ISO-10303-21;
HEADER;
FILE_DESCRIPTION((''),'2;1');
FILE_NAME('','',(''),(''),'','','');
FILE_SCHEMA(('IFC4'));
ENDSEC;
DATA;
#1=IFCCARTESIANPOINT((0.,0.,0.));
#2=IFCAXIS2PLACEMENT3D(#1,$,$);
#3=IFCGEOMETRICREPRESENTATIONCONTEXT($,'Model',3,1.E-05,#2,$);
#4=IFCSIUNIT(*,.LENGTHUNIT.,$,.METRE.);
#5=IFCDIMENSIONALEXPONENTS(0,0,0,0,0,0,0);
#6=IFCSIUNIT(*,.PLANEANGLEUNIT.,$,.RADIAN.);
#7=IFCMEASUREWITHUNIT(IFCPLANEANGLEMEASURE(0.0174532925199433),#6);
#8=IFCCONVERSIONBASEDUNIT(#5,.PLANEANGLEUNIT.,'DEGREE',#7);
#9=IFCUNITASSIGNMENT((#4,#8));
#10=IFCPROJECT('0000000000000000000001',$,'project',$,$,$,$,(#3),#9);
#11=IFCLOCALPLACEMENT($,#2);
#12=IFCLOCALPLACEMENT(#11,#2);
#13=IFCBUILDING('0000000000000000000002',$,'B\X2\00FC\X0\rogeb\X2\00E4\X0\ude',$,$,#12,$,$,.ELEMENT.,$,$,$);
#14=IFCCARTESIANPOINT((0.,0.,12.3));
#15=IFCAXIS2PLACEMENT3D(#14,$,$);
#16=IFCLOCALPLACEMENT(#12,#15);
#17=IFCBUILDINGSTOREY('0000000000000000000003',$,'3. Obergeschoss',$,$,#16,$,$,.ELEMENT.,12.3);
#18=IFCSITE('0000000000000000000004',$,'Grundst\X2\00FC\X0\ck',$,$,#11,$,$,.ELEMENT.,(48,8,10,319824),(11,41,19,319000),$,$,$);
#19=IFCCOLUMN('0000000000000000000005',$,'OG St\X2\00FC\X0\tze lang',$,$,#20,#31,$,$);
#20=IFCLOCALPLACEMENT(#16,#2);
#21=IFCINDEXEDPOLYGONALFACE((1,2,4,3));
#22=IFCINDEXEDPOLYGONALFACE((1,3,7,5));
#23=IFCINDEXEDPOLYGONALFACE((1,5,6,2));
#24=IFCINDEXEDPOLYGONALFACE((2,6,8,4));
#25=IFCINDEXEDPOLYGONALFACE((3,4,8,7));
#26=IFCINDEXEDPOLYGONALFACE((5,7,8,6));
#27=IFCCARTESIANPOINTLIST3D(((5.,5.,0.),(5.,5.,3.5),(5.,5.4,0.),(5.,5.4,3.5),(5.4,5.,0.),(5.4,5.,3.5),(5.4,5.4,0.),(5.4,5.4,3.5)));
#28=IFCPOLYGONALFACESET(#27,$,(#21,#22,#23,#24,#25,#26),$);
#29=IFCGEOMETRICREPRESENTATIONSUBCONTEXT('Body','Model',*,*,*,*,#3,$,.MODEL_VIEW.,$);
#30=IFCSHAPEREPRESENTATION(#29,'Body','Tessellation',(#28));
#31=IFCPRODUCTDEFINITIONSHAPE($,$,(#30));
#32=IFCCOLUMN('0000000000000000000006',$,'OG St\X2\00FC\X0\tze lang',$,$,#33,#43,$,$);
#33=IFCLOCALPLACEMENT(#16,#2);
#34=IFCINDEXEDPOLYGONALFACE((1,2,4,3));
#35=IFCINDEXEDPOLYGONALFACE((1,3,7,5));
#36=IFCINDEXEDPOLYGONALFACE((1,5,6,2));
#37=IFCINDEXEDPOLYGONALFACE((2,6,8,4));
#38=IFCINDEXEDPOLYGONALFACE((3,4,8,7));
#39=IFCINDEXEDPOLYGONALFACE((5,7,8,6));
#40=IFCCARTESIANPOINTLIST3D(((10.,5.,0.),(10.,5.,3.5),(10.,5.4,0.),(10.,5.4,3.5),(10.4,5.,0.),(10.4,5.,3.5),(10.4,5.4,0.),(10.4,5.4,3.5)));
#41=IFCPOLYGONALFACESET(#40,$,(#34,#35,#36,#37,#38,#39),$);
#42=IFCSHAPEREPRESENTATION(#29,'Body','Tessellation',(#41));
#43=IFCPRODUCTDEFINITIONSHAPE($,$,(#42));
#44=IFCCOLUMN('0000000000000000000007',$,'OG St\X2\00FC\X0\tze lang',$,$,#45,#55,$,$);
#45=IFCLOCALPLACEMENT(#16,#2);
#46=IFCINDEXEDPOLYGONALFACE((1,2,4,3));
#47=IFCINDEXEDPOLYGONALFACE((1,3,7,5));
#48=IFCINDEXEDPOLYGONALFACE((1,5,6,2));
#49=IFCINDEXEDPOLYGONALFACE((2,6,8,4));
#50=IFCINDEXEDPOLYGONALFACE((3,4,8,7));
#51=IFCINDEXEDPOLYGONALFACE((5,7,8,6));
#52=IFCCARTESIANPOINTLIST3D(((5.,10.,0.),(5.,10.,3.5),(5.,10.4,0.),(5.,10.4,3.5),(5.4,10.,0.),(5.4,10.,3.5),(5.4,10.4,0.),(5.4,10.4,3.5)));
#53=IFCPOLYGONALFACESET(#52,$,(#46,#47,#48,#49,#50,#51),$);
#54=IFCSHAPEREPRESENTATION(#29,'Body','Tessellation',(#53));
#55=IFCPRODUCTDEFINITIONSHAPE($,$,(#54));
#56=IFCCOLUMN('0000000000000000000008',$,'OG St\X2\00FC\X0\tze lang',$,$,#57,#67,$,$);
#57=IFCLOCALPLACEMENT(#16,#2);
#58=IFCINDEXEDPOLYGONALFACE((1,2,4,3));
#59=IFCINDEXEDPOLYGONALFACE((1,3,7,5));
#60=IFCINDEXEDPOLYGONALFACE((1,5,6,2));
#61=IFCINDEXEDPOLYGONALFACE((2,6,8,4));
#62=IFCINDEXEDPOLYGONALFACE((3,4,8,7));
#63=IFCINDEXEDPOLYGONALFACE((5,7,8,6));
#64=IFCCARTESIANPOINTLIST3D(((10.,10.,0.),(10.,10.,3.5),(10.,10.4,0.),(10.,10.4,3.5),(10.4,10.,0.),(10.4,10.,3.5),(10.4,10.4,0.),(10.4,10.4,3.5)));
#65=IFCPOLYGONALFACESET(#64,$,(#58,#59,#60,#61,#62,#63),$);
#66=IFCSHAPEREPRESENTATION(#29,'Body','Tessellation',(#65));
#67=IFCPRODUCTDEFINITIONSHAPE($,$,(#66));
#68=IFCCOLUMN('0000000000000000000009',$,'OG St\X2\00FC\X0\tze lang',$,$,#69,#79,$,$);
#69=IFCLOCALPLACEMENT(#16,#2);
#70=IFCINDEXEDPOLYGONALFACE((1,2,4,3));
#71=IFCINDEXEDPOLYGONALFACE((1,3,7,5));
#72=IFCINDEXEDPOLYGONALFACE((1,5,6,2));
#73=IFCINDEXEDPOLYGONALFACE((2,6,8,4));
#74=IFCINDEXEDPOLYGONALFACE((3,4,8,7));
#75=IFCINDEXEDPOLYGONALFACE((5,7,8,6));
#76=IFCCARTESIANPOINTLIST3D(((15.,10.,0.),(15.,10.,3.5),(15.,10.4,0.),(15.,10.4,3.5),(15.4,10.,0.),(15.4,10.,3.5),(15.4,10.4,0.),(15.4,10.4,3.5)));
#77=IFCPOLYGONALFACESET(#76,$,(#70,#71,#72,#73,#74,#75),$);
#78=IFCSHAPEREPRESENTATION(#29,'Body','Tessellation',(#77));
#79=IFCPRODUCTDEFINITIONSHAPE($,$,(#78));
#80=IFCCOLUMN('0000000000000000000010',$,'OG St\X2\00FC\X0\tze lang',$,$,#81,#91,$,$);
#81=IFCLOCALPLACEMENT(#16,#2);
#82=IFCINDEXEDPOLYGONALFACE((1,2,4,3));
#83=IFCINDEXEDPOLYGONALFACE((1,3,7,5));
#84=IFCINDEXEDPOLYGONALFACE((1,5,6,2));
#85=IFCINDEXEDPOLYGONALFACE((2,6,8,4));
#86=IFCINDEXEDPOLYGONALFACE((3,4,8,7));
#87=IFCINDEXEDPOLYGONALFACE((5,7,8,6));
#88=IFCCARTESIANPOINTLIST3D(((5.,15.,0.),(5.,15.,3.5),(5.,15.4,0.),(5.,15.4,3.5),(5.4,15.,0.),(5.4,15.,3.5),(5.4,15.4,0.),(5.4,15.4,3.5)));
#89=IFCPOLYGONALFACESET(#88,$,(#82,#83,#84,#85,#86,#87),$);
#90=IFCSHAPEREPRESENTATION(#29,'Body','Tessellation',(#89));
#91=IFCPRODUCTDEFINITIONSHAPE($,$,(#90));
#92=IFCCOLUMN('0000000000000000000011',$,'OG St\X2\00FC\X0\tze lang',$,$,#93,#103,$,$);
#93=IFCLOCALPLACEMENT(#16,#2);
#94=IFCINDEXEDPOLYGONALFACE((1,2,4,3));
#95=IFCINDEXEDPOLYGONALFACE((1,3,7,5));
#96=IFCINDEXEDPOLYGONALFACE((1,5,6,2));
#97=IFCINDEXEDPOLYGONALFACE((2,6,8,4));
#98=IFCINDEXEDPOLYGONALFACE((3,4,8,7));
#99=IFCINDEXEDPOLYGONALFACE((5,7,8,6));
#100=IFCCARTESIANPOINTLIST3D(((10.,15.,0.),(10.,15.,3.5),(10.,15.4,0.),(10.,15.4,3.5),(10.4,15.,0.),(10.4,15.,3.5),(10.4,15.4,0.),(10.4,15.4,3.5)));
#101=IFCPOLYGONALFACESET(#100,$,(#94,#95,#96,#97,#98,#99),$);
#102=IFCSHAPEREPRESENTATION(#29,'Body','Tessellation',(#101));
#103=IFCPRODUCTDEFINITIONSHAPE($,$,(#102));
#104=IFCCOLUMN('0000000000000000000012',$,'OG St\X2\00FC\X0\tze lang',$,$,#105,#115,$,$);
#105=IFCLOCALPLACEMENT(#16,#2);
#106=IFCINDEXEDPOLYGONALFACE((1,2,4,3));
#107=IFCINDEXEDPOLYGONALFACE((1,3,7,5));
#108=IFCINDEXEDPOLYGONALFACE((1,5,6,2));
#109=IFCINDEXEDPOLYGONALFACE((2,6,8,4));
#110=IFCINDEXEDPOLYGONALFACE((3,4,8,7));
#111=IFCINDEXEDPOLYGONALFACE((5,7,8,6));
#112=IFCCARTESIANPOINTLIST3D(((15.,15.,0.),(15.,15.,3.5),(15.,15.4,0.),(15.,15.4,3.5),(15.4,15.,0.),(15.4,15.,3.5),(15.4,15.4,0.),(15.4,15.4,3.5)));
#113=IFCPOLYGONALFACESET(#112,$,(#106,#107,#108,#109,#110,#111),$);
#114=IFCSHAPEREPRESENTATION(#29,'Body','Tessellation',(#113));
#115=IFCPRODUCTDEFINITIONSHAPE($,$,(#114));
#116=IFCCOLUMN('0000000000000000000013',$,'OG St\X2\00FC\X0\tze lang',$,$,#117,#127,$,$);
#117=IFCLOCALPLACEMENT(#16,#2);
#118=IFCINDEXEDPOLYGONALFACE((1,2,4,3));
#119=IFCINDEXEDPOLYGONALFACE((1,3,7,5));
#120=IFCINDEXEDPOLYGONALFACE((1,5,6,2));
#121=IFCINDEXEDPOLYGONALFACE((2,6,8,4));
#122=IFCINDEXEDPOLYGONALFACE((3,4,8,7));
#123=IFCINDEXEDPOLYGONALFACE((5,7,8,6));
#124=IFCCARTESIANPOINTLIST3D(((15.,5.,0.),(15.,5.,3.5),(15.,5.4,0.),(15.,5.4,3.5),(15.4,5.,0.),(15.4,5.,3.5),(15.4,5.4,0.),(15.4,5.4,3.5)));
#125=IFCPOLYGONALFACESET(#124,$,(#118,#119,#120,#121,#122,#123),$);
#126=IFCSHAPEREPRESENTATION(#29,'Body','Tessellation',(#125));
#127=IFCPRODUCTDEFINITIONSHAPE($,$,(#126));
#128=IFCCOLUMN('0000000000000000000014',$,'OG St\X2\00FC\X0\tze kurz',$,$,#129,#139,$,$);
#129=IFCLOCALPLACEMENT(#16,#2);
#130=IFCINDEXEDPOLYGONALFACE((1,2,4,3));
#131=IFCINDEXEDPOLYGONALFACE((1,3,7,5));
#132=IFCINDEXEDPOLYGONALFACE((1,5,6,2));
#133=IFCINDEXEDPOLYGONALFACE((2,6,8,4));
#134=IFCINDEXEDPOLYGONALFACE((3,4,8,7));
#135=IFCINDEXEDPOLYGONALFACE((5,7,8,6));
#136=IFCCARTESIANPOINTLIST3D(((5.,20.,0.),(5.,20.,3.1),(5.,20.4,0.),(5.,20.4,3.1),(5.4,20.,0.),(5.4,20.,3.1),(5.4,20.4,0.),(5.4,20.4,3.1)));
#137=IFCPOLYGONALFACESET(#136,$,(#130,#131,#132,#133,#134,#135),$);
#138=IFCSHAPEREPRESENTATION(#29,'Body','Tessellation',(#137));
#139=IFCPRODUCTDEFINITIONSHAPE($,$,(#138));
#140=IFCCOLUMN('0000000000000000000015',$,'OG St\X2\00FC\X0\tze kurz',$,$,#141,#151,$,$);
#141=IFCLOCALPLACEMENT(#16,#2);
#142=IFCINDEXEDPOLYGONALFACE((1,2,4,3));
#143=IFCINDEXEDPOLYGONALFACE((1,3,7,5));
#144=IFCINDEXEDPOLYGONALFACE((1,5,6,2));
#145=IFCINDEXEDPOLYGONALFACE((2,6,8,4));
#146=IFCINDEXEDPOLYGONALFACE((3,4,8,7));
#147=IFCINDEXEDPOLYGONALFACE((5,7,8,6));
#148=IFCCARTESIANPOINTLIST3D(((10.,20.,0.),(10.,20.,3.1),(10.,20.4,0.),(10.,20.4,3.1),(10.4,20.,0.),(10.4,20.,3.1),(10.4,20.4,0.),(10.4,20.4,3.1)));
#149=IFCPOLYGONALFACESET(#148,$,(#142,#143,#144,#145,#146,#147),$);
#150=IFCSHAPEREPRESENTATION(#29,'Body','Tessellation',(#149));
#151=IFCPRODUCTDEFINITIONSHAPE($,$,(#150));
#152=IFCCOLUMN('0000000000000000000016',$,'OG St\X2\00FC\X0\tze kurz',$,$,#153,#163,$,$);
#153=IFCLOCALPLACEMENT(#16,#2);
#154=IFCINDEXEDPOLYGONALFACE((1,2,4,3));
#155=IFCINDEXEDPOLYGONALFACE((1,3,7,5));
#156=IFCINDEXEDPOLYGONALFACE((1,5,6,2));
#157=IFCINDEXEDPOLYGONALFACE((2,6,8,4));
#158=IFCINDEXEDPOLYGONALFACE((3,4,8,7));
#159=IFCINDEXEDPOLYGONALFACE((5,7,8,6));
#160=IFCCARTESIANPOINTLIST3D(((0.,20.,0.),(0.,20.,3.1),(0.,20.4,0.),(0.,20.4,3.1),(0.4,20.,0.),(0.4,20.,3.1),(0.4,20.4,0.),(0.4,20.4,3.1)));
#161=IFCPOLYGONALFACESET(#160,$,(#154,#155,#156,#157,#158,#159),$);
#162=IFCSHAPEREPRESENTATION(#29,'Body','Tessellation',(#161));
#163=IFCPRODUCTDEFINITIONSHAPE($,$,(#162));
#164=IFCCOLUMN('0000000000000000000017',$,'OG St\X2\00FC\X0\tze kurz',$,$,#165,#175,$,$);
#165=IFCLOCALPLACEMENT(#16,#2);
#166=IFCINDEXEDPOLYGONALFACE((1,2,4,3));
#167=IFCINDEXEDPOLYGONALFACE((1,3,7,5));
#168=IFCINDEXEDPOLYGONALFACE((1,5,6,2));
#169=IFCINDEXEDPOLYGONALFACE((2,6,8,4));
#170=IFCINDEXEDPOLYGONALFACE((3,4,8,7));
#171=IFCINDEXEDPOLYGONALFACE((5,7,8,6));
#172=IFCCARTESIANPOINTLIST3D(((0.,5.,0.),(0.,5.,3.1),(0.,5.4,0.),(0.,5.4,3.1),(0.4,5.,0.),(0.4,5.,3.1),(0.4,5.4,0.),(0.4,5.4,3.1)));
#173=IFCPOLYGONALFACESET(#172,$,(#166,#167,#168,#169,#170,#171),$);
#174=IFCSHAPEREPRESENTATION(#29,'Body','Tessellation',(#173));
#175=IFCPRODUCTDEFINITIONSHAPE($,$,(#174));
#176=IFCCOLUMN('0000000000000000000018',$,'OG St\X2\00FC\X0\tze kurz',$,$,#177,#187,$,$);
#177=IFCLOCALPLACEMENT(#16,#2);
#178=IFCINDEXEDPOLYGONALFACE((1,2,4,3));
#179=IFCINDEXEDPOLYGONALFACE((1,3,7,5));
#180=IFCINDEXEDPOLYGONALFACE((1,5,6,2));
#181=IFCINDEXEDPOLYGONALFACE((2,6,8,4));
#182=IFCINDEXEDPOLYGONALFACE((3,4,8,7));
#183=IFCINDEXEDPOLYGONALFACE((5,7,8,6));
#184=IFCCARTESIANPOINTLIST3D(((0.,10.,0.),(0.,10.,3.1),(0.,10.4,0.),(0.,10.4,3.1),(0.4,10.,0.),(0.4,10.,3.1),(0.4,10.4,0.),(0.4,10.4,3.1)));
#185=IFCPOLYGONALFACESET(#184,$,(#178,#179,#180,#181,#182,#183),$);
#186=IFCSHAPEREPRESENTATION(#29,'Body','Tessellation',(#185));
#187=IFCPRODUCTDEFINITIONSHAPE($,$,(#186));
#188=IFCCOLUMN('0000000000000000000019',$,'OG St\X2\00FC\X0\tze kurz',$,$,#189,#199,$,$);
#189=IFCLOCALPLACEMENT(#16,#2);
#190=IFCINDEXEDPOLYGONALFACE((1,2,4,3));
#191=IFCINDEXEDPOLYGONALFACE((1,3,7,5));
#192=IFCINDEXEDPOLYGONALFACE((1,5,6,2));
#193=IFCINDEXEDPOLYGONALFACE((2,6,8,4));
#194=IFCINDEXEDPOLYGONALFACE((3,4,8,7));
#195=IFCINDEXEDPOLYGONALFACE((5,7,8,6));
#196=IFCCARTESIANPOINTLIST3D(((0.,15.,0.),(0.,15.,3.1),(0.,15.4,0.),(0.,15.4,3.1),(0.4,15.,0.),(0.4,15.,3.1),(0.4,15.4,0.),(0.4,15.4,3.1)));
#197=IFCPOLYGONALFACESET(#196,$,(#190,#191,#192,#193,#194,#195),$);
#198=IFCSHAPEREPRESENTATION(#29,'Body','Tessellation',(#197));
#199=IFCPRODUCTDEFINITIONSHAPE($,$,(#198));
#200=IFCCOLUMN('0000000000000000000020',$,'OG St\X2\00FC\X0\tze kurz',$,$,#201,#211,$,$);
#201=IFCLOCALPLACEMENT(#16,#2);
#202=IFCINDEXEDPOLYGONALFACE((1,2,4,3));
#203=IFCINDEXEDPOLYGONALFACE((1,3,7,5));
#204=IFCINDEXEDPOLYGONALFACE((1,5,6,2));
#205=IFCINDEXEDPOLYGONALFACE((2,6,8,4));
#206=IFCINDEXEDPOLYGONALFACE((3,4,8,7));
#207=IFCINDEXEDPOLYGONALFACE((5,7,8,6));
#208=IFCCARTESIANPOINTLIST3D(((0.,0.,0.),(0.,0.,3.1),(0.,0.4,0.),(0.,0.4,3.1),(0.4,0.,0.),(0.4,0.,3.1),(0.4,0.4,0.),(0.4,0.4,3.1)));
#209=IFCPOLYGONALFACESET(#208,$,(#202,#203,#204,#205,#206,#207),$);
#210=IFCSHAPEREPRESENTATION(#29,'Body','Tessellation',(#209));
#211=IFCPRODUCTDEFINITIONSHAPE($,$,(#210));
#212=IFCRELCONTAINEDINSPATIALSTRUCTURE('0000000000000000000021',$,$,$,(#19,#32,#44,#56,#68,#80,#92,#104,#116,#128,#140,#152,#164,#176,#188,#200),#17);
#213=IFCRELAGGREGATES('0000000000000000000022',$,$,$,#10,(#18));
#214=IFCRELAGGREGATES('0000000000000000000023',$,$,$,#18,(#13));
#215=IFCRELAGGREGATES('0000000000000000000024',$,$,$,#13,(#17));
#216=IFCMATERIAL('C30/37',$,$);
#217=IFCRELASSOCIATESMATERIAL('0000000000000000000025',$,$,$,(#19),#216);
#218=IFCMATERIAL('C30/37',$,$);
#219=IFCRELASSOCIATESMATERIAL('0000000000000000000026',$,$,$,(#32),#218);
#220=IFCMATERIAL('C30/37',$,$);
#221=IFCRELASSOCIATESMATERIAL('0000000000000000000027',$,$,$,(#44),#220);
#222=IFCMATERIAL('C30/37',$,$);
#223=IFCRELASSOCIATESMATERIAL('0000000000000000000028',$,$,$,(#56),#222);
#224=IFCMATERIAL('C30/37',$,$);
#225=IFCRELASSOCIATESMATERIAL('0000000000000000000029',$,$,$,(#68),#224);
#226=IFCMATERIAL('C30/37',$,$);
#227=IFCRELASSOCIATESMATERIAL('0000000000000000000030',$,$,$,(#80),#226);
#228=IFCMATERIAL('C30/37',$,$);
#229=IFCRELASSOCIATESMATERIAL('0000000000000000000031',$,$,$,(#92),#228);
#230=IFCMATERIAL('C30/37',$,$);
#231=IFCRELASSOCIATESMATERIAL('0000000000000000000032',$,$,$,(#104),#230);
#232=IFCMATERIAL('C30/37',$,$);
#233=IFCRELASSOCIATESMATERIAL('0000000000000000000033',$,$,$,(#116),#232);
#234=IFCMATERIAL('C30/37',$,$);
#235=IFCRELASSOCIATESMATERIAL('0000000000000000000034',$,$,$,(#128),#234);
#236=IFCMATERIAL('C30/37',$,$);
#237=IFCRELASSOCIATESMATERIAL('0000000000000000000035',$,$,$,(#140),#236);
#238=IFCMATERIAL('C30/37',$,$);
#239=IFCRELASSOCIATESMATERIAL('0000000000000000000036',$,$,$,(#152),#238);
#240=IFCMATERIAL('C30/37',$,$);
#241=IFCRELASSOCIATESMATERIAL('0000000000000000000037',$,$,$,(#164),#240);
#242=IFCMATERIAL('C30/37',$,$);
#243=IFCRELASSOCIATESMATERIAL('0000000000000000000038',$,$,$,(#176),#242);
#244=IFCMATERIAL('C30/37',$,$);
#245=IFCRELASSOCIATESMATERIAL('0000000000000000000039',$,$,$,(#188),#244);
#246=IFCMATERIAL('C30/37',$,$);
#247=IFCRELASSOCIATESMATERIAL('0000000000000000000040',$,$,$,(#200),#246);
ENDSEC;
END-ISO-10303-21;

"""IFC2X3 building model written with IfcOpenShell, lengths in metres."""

from ifc_helpers import new_model, entity, si_unit, converted_unit, frame, frame_2d, origin, origin_with_axes, place, context, subcontext, project, spatial, rectangle, extrude, material, element, save


model = new_model("IFC2X3")

# Units and contexts
model_context = context("Model", 3, precision=1e-05, world=origin())
body_context = subcontext(model_context, "Body", "Model", "MODEL_VIEW")
ifc_project = project(units=[si_unit("LENGTHUNIT", "METRE"), converted_unit("PLANEANGLEUNIT", "DEGREE", entity("IfcPlaneAngleMeasure", 0.0174532925199433), si_unit("PLANEANGLEUNIT", "RADIAN"), dimensions=[0, 0, 0, 0, 0, 0, 0])], contexts=[model_context])

# Site, building, storey
site_placement = place(None, origin())
site = spatial("IfcSite", under=ifc_project, at=site_placement, Name="Grundstück", CompositionType="ELEMENT", RefLatitude=(48, 8, 10, 319824), RefLongitude=(11, 41, 19, 319000))
building_placement = place(site_placement, origin())
building = spatial("IfcBuilding", under=site, at=building_placement, Name="Bürogebäude", CompositionType="ELEMENT")
storey_placement = place(building_placement, frame((0.0, 0.0, 12.3)))
storey = spatial("IfcBuildingStorey", under=building, at=storey_placement, Name="3. Obergeschoss", CompositionType="ELEMENT", Elevation=12.3)

# Columns
ifc_material_1 = material(Name="C30/37")
column_1_placement = place(storey_placement, frame((5.0, 5.0, 0.0)))
element("IfcColumn", 1, at=column_1_placement, inside=storey, material=ifc_material_1, Name="OG Stütze lang", context=body_context, shape_type="SweptSolid", body=[
    extrude(rectangle(XDim=0.4, YDim=0.4, at=frame_2d((0.2, 0.2), x_axis=(1.0, 0.0))), origin_with_axes(), (0.0, 0.0, 1.0), 3.5),
])
ifc_material_2 = material(Name="C30/37")
column_2_placement = place(storey_placement, frame((10.0, 5.0, 0.0)))
element("IfcColumn", 2, at=column_2_placement, inside=storey, material=ifc_material_2, Name="OG Stütze lang", context=body_context, shape_type="SweptSolid", body=[
    extrude(rectangle(XDim=0.4, YDim=0.4, at=frame_2d((0.2, 0.2), x_axis=(1.0, 0.0))), origin_with_axes(), (0.0, 0.0, 1.0), 3.5),
])
ifc_material_3 = material(Name="C30/37")
column_3_placement = place(storey_placement, frame((5.0, 10.0, 0.0)))
element("IfcColumn", 3, at=column_3_placement, inside=storey, material=ifc_material_3, Name="OG Stütze lang", context=body_context, shape_type="SweptSolid", body=[
    extrude(rectangle(XDim=0.4, YDim=0.4, at=frame_2d((0.2, 0.2), x_axis=(1.0, 0.0))), origin_with_axes(), (0.0, 0.0, 1.0), 3.5),
])
ifc_material_4 = material(Name="C30/37")
column_4_placement = place(storey_placement, frame((10.0, 10.0, 0.0)))
element("IfcColumn", 4, at=column_4_placement, inside=storey, material=ifc_material_4, Name="OG Stütze lang", context=body_context, shape_type="SweptSolid", body=[
    extrude(rectangle(XDim=0.4, YDim=0.4, at=frame_2d((0.2, 0.2), x_axis=(1.0, 0.0))), origin_with_axes(), (0.0, 0.0, 1.0), 3.5),
])
ifc_material_5 = material(Name="C30/37")
column_5_placement = place(storey_placement, frame((15.0, 10.0, 0.0)))
element("IfcColumn", 5, at=column_5_placement, inside=storey, material=ifc_material_5, Name="OG Stütze lang", context=body_context, shape_type="SweptSolid", body=[
    extrude(rectangle(XDim=0.4, YDim=0.4, at=frame_2d((0.2, 0.2), x_axis=(1.0, 0.0))), origin_with_axes(), (0.0, 0.0, 1.0), 3.5),
])
ifc_material_6 = material(Name="C30/37")
column_6_placement = place(storey_placement, frame((5.0, 15.0, 0.0)))
element("IfcColumn", 6, at=column_6_placement, inside=storey, material=ifc_material_6, Name="OG Stütze lang", context=body_context, shape_type="SweptSolid", body=[
    extrude(rectangle(XDim=0.4, YDim=0.4, at=frame_2d((0.2, 0.2), x_axis=(1.0, 0.0))), origin_with_axes(), (0.0, 0.0, 1.0), 3.5),
])
ifc_material_7 = material(Name="C30/37")
column_7_placement = place(storey_placement, frame((10.0, 15.0, 0.0)))
element("IfcColumn", 7, at=column_7_placement, inside=storey, material=ifc_material_7, Name="OG Stütze lang", context=body_context, shape_type="SweptSolid", body=[
    extrude(rectangle(XDim=0.4, YDim=0.4, at=frame_2d((0.2, 0.2), x_axis=(1.0, 0.0))), origin_with_axes(), (0.0, 0.0, 1.0), 3.5),
])
ifc_material_8 = material(Name="C30/37")
column_8_placement = place(storey_placement, frame((15.0, 15.0, 0.0)))
element("IfcColumn", 8, at=column_8_placement, inside=storey, material=ifc_material_8, Name="OG Stütze lang", context=body_context, shape_type="SweptSolid", body=[
    extrude(rectangle(XDim=0.4, YDim=0.4, at=frame_2d((0.2, 0.2), x_axis=(1.0, 0.0))), origin_with_axes(), (0.0, 0.0, 1.0), 3.5),
])
ifc_material_9 = material(Name="C30/37")
column_9_placement = place(storey_placement, frame((15.0, 5.0, 0.0)))
element("IfcColumn", 9, at=column_9_placement, inside=storey, material=ifc_material_9, Name="OG Stütze lang", context=body_context, shape_type="SweptSolid", body=[
    extrude(rectangle(XDim=0.4, YDim=0.4, at=frame_2d((0.2, 0.2), x_axis=(1.0, 0.0))), origin_with_axes(), (0.0, 0.0, 1.0), 3.5),
])
ifc_material_10 = material(Name="C30/37")
column_10_placement = place(storey_placement, frame((5.0, 20.0, 0.0)))
element("IfcColumn", 10, at=column_10_placement, inside=storey, material=ifc_material_10, Name="OG Stütze kurz", context=body_context, shape_type="SweptSolid", body=[
    extrude(rectangle(XDim=0.4, YDim=0.4, at=frame_2d((0.2, 0.2), x_axis=(1.0, 0.0))), origin_with_axes(), (0.0, 0.0, 1.0), 3.1),
])
ifc_material_11 = material(Name="C30/37")
column_11_placement = place(storey_placement, frame((10.0, 20.0, 0.0)))
element("IfcColumn", 11, at=column_11_placement, inside=storey, material=ifc_material_11, Name="OG Stütze kurz", context=body_context, shape_type="SweptSolid", body=[
    extrude(rectangle(XDim=0.4, YDim=0.4, at=frame_2d((0.2, 0.2), x_axis=(1.0, 0.0))), origin_with_axes(), (0.0, 0.0, 1.0), 3.1),
])
ifc_material_12 = material(Name="C30/37")
column_12_placement = place(storey_placement, frame((0.0, 20.0, 0.0)))
element("IfcColumn", 12, at=column_12_placement, inside=storey, material=ifc_material_12, Name="OG Stütze kurz", context=body_context, shape_type="SweptSolid", body=[
    extrude(rectangle(XDim=0.4, YDim=0.4, at=frame_2d((0.2, 0.2), x_axis=(1.0, 0.0))), origin_with_axes(), (0.0, 0.0, 1.0), 3.1),
])
ifc_material_13 = material(Name="C30/37")
column_13_placement = place(storey_placement, frame((0.0, 5.0, 0.0)))
element("IfcColumn", 13, at=column_13_placement, inside=storey, material=ifc_material_13, Name="OG Stütze kurz", context=body_context, shape_type="SweptSolid", body=[
    extrude(rectangle(XDim=0.4, YDim=0.4, at=frame_2d((0.2, 0.2), x_axis=(1.0, 0.0))), origin_with_axes(), (0.0, 0.0, 1.0), 3.1),
])
ifc_material_14 = material(Name="C30/37")
column_14_placement = place(storey_placement, frame((0.0, 10.0, 0.0)))
element("IfcColumn", 14, at=column_14_placement, inside=storey, material=ifc_material_14, Name="OG Stütze kurz", context=body_context, shape_type="SweptSolid", body=[
    extrude(rectangle(XDim=0.4, YDim=0.4, at=frame_2d((0.2, 0.2), x_axis=(1.0, 0.0))), origin_with_axes(), (0.0, 0.0, 1.0), 3.1),
])
ifc_material_15 = material(Name="C30/37")
column_15_placement = place(storey_placement, frame((0.0, 15.0, 0.0)))
element("IfcColumn", 15, at=column_15_placement, inside=storey, material=ifc_material_15, Name="OG Stütze kurz", context=body_context, shape_type="SweptSolid", body=[
    extrude(rectangle(XDim=0.4, YDim=0.4, at=frame_2d((0.2, 0.2), x_axis=(1.0, 0.0))), origin_with_axes(), (0.0, 0.0, 1.0), 3.1),
])
ifc_material_16 = material(Name="C30/37")
column_16_placement = place(storey_placement, origin())
element("IfcColumn", 16, at=column_16_placement, inside=storey, material=ifc_material_16, Name="OG Stütze kurz", context=body_context, shape_type="SweptSolid", body=[
    extrude(rectangle(XDim=0.4, YDim=0.4, at=frame_2d((0.2, 0.2), x_axis=(1.0, 0.0))), origin_with_axes(), (0.0, 0.0, 1.0), 3.1),
])

save(model, "model.ifc")
